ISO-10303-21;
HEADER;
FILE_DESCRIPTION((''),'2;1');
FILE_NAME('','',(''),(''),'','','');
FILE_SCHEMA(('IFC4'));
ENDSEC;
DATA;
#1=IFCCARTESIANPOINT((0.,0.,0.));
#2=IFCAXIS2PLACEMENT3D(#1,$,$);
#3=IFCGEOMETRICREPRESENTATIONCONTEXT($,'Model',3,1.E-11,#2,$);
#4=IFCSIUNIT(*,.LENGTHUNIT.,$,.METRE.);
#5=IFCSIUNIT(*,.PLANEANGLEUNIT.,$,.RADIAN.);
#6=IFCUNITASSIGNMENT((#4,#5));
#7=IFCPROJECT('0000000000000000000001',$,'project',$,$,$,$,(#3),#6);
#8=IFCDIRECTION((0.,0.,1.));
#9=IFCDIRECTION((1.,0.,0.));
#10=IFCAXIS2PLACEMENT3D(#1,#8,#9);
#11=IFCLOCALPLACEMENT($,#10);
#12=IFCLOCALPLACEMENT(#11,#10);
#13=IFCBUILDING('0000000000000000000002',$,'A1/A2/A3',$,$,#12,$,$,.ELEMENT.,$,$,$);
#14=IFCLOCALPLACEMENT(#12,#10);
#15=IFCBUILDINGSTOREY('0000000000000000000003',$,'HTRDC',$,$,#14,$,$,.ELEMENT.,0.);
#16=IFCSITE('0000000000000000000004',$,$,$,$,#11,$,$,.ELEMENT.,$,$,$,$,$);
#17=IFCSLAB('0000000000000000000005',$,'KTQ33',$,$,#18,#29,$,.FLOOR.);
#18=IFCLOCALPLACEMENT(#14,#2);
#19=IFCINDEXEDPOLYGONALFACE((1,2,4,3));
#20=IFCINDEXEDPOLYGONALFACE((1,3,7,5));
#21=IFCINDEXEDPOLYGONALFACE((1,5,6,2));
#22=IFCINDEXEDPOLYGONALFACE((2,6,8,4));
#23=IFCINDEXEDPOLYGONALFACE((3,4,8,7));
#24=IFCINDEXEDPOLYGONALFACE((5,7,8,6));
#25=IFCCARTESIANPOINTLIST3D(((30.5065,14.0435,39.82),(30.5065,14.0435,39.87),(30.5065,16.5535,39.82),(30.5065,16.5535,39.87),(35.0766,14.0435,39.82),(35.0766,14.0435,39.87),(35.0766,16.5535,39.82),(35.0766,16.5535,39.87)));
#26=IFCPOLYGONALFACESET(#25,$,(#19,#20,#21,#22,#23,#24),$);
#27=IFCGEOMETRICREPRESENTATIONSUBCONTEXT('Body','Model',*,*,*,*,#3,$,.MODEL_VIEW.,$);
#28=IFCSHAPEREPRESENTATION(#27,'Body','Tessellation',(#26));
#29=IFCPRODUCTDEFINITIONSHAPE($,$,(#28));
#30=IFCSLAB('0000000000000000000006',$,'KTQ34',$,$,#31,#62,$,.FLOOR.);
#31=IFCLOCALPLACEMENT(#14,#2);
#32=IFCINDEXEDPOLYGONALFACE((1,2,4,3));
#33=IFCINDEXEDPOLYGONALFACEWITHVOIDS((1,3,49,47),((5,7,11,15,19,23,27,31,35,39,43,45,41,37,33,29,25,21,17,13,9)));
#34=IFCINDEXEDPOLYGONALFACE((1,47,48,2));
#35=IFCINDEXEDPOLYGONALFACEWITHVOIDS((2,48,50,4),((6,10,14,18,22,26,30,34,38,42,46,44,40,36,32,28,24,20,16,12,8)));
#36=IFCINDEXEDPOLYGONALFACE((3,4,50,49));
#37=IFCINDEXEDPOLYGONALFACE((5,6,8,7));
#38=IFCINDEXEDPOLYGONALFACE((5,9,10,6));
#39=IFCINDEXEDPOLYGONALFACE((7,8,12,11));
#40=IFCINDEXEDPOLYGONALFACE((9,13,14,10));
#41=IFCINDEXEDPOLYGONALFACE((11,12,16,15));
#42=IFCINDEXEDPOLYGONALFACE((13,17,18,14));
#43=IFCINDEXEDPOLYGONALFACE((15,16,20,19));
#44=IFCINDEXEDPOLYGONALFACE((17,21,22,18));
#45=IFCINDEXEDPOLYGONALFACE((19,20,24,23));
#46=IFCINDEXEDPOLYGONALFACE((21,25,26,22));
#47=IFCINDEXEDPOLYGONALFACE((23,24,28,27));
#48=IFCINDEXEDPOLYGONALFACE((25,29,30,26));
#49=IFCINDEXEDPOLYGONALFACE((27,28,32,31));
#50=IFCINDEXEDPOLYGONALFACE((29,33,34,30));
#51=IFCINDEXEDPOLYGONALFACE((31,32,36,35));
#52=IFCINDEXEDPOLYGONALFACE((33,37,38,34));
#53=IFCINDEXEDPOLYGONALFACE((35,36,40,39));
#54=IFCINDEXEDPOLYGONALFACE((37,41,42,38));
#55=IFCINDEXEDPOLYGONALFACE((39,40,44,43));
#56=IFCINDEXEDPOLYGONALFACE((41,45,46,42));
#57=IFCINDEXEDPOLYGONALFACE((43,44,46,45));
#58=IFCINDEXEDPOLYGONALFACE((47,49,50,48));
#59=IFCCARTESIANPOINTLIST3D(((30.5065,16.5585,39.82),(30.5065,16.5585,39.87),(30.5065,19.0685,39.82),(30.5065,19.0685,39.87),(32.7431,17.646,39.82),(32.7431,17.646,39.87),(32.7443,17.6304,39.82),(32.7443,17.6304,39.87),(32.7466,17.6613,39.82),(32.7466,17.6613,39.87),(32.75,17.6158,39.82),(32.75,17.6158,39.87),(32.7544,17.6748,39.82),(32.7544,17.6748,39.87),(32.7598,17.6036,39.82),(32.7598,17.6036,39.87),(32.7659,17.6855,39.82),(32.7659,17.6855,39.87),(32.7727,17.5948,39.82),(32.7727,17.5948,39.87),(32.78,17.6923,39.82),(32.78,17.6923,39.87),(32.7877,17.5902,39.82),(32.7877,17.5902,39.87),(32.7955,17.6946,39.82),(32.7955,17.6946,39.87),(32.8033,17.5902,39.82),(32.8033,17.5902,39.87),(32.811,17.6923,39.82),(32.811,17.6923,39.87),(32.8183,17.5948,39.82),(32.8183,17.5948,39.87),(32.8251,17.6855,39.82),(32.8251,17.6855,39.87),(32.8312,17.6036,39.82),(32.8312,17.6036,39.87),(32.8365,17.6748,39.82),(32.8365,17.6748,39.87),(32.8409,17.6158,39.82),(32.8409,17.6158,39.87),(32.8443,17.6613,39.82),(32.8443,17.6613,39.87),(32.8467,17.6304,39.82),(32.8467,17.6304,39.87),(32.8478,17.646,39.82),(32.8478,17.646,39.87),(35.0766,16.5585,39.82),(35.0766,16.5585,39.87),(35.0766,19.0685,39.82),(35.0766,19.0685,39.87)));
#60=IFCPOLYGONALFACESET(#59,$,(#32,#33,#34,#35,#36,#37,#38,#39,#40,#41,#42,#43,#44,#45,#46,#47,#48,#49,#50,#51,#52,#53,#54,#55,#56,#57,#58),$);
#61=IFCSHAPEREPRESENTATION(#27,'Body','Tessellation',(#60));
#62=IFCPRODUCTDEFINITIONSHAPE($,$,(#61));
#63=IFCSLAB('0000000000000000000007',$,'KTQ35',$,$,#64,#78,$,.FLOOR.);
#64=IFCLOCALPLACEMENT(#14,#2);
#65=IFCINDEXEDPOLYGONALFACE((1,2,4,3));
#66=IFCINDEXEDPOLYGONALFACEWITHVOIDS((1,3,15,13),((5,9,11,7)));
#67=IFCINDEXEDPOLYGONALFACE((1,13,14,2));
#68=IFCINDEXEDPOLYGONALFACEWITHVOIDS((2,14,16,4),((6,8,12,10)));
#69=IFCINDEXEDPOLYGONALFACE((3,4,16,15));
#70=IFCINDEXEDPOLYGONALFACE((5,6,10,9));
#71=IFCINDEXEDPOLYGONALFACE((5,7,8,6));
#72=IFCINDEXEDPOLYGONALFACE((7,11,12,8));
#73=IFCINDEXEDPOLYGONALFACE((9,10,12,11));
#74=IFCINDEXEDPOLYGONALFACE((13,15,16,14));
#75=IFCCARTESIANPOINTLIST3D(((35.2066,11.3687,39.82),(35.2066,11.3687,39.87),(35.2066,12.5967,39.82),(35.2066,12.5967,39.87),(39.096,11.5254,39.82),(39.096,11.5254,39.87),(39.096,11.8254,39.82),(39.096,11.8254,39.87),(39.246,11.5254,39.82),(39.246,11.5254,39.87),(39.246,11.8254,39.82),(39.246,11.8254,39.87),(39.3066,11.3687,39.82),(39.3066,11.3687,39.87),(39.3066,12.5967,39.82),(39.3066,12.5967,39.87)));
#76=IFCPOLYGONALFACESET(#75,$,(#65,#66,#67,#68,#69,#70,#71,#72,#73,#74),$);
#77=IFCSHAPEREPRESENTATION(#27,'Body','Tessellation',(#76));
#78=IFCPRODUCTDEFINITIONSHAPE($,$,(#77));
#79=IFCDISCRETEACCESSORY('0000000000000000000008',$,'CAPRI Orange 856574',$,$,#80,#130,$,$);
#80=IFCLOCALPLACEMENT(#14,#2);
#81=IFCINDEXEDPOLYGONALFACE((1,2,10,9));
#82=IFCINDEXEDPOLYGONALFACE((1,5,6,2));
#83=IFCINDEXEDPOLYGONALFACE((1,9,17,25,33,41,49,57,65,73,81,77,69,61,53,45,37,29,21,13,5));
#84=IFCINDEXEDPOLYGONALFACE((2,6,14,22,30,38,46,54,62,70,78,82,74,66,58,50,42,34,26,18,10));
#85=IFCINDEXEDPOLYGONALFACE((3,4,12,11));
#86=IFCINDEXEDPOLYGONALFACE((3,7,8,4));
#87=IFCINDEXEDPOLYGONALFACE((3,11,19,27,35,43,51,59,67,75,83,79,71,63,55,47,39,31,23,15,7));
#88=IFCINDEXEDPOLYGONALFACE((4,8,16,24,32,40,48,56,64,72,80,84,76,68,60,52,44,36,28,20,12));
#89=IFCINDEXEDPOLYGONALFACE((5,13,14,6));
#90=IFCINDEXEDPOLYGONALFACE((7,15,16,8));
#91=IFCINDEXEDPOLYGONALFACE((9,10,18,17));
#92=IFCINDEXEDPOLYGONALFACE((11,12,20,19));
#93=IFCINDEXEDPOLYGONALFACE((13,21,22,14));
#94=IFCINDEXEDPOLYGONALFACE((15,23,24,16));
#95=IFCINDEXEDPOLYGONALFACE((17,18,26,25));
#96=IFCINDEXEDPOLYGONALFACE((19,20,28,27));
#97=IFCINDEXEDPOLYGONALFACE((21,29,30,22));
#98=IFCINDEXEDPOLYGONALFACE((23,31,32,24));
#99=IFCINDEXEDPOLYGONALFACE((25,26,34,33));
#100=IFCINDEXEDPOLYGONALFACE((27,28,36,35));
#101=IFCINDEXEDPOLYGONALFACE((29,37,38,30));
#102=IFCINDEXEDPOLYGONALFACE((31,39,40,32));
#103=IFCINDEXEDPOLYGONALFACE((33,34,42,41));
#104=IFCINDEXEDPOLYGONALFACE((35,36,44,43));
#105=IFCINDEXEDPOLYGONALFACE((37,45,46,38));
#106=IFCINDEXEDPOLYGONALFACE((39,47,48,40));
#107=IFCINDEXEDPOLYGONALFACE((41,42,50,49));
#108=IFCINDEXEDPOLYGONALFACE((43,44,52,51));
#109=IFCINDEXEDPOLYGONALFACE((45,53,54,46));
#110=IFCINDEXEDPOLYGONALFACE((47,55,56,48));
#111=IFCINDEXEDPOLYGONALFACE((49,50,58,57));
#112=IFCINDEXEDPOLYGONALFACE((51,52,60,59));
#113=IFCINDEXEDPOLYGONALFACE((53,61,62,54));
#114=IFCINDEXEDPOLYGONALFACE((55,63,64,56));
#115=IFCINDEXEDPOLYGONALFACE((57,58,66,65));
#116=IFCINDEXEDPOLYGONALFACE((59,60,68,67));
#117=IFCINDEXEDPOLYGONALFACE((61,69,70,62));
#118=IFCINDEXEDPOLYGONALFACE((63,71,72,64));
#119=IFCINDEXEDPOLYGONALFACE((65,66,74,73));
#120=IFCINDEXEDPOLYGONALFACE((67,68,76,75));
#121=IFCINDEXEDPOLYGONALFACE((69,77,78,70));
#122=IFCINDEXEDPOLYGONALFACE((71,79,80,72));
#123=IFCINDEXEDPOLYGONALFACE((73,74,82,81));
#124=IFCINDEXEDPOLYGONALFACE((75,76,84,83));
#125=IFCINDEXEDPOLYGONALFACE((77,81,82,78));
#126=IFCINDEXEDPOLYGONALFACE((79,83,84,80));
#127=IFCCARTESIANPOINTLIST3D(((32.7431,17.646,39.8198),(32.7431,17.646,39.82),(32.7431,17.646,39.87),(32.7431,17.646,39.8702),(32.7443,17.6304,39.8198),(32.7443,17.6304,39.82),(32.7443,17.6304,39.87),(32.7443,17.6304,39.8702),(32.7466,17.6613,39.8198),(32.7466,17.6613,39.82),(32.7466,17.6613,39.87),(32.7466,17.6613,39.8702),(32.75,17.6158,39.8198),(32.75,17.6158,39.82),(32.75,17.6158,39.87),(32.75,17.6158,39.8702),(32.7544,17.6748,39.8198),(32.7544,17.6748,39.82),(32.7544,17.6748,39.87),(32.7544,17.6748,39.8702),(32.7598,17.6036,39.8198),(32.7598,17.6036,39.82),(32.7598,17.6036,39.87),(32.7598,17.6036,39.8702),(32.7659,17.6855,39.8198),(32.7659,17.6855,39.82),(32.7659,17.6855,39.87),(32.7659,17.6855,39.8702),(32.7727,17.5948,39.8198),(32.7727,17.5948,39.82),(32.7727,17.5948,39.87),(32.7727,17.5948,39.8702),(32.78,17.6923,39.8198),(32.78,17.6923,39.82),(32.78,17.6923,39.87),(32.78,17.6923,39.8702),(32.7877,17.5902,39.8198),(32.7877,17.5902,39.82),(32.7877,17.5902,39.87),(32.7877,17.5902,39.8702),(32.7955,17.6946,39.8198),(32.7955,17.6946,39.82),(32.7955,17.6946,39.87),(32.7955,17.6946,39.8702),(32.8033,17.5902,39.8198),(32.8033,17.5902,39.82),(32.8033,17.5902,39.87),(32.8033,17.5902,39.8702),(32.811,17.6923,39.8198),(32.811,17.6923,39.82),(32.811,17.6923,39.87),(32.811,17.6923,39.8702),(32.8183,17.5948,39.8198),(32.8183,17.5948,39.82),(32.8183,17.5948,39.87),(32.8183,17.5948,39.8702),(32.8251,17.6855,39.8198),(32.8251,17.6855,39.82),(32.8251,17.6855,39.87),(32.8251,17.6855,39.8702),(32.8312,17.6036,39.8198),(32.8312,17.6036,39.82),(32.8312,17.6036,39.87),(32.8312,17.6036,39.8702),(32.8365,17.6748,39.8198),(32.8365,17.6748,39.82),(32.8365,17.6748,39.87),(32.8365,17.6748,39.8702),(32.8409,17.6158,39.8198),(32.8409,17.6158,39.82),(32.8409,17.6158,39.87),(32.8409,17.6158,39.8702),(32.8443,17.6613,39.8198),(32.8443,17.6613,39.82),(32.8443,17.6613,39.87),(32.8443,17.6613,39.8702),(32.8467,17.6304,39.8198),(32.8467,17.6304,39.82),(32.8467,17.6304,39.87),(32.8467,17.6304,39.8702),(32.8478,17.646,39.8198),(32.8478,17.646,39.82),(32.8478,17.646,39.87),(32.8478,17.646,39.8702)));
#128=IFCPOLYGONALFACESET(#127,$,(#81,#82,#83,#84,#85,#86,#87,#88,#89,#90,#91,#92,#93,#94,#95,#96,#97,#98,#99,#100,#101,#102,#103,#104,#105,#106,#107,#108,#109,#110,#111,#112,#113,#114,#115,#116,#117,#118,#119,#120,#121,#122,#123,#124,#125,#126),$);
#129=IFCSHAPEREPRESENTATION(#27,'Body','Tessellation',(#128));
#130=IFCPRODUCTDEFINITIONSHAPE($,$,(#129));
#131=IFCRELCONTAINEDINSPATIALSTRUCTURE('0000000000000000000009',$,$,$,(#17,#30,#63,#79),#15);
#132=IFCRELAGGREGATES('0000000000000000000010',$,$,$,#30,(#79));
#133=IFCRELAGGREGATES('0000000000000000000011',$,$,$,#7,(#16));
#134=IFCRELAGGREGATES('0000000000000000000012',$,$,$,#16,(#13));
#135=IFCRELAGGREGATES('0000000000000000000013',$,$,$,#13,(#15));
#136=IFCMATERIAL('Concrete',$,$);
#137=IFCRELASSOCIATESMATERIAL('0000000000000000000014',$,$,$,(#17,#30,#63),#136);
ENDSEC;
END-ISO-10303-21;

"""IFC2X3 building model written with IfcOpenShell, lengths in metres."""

from ifc_helpers import new_model, si_unit, frame, frame_2d, origin, origin_with_axes, origin_2d_with_axis, place, context, subcontext, project, spatial, polyline, circle, outline, extrude, material, element, aggregate, save


model = new_model("IFC2X3")

# Units and contexts
model_context = context("Model", 3, precision=1e-11, world=origin())
body_context = subcontext(model_context, "Body", "Model", "MODEL_VIEW")
ifc_project = project(units=[si_unit("LENGTHUNIT", "METRE"), si_unit("PLANEANGLEUNIT", "RADIAN")], contexts=[model_context])

# Site, building, storey
site_placement = place(None, origin_with_axes())
site = spatial("IfcSite", under=ifc_project, at=site_placement, CompositionType="ELEMENT")
building_placement = place(site_placement, origin_with_axes())
building = spatial("IfcBuilding", under=site, at=building_placement, Name="A1/A2/A3", CompositionType="ELEMENT")
storey_placement = place(building_placement, origin_with_axes())
storey = spatial("IfcBuildingStorey", under=building, at=storey_placement, Name="HTRDC", CompositionType="ELEMENT", Elevation=0.0)

# Slab
ifc_material = material(Name="Concrete")
slab_1_placement = place(storey_placement, frame((30.5065, 14.0435, 39.82), z_axis=(0.0, 0.0, 1.0), x_axis=(1.0, 0.0, 0.0)))
element("IfcSlab", 1, at=slab_1_placement, inside=storey, material=ifc_material, Name="KTQ33", PredefinedType="FLOOR", context=body_context, shape_type="SweptSolid", body=[
    extrude(outline(polyline([(0.0, 0.0), (0.0, -4.57), (2.51, -4.57), (2.51, 0.0), (0.0, 0.0)])), frame((0.0, 0.0, 0.0), z_axis=(0.0, 0.0, 1.0), x_axis=(0.0, 1.0, 0.0)), (0.0, 0.0, 1.0), 0.05),
])

# Slabs, openings
slab_2_placement = place(storey_placement, frame((30.5065, 16.5585, 39.82), z_axis=(0.0, 0.0, 1.0), x_axis=(1.0, 0.0, 0.0)))
slab_2 = element("IfcSlab", 2, at=slab_2_placement, inside=storey, material=ifc_material, Name="KTQ34", PredefinedType="FLOOR", context=body_context, shape_type="SweptSolid", body=[
    extrude(outline(polyline([(0.0, 0.0), (0.0, -4.57), (2.51, -4.57), (2.51, 0.0), (0.0, 0.0)])), frame((0.0, 0.0, 0.0), z_axis=(0.0, 0.0, 1.0), x_axis=(0.0, 1.0, 0.0)), (0.0, 0.0, 1.0), 0.05),
])
opening_1_placement = place(slab_2_placement, frame((2.2889, 1.0836, 0.0), z_axis=(0.0, 0.0, 1.0), x_axis=(1.0, 0.0, 0.0)))
element("IfcOpeningElement", 3, at=opening_1_placement, cuts=slab_2, ObjectType="Opening", context=body_context, shape_type="SweptSolid", body=[
    extrude(circle(Radius=0.0525, at=origin_2d_with_axis()), frame((0.0, 0.0, 0.0), z_axis=(0.0, 0.0, 1.0), x_axis=(0.0, 1.0, 0.0)), (0.0, 0.0, 1.0), 0.05),
])
slab_3_placement = place(storey_placement, frame((35.2066, 11.3687, 39.82), z_axis=(0.0, 0.0, 1.0), x_axis=(1.0, 0.0, 0.0)))
slab_3 = element("IfcSlab", 4, at=slab_3_placement, inside=storey, material=ifc_material, Name="KTQ35", PredefinedType="FLOOR", context=body_context, shape_type="SweptSolid", body=[
    extrude(outline(polyline([(0.0, 0.0), (0.0, -4.1), (1.228, -4.1), (1.228, 0.0), (0.0, 0.0)])), frame((0.0, 0.0, 0.0), z_axis=(0.0, 0.0, 1.0), x_axis=(0.0, 1.0, 0.0)), (0.0, 0.0, 1.0), 0.05),
])
opening_2_placement = place(slab_3_placement, origin_with_axes())
element("IfcOpeningElement", 5, at=opening_2_placement, cuts=slab_3, ObjectType="Opening", context=body_context, shape_type="SweptSolid", body=[
    extrude(outline(polyline([(0.1566, -3.8894), (0.1566, -4.0394), (0.4566, -4.0394), (0.4566, -3.8894), (0.1566, -3.8894)])), frame((0.0, 0.0, 0.0), z_axis=(0.0, 0.0, 1.0), x_axis=(0.0, 1.0, 0.0)), (0.0, 0.0, 1.0), 0.05),
])

# Discrete accessory
discrete_accessory_1_placement = place(storey_placement, frame((30.5065, 16.5585, 39.8199), z_axis=(0.0, 0.0, 1.0), x_axis=(1.0, 0.0, 0.0)))
discrete_accessory_1 = element("IfcDiscreteAccessory", 6, at=discrete_accessory_1_placement, inside=storey, Name="CAPRI Orange 856574", context=body_context, shape_type="SweptSolid", body=[
    extrude(circle(Radius=0.0525, at=frame_2d((1.0836, -2.2889), x_axis=(1.0, 0.0))), frame((0.0, 0.0, 0.0), z_axis=(0.0, 0.0, 1.0), x_axis=(0.0, 1.0, 0.0)), (0.0, 0.0, 1.0), 0.0503),
])
aggregate(slab_2, [discrete_accessory_1])

save(model, "model.ifc")
